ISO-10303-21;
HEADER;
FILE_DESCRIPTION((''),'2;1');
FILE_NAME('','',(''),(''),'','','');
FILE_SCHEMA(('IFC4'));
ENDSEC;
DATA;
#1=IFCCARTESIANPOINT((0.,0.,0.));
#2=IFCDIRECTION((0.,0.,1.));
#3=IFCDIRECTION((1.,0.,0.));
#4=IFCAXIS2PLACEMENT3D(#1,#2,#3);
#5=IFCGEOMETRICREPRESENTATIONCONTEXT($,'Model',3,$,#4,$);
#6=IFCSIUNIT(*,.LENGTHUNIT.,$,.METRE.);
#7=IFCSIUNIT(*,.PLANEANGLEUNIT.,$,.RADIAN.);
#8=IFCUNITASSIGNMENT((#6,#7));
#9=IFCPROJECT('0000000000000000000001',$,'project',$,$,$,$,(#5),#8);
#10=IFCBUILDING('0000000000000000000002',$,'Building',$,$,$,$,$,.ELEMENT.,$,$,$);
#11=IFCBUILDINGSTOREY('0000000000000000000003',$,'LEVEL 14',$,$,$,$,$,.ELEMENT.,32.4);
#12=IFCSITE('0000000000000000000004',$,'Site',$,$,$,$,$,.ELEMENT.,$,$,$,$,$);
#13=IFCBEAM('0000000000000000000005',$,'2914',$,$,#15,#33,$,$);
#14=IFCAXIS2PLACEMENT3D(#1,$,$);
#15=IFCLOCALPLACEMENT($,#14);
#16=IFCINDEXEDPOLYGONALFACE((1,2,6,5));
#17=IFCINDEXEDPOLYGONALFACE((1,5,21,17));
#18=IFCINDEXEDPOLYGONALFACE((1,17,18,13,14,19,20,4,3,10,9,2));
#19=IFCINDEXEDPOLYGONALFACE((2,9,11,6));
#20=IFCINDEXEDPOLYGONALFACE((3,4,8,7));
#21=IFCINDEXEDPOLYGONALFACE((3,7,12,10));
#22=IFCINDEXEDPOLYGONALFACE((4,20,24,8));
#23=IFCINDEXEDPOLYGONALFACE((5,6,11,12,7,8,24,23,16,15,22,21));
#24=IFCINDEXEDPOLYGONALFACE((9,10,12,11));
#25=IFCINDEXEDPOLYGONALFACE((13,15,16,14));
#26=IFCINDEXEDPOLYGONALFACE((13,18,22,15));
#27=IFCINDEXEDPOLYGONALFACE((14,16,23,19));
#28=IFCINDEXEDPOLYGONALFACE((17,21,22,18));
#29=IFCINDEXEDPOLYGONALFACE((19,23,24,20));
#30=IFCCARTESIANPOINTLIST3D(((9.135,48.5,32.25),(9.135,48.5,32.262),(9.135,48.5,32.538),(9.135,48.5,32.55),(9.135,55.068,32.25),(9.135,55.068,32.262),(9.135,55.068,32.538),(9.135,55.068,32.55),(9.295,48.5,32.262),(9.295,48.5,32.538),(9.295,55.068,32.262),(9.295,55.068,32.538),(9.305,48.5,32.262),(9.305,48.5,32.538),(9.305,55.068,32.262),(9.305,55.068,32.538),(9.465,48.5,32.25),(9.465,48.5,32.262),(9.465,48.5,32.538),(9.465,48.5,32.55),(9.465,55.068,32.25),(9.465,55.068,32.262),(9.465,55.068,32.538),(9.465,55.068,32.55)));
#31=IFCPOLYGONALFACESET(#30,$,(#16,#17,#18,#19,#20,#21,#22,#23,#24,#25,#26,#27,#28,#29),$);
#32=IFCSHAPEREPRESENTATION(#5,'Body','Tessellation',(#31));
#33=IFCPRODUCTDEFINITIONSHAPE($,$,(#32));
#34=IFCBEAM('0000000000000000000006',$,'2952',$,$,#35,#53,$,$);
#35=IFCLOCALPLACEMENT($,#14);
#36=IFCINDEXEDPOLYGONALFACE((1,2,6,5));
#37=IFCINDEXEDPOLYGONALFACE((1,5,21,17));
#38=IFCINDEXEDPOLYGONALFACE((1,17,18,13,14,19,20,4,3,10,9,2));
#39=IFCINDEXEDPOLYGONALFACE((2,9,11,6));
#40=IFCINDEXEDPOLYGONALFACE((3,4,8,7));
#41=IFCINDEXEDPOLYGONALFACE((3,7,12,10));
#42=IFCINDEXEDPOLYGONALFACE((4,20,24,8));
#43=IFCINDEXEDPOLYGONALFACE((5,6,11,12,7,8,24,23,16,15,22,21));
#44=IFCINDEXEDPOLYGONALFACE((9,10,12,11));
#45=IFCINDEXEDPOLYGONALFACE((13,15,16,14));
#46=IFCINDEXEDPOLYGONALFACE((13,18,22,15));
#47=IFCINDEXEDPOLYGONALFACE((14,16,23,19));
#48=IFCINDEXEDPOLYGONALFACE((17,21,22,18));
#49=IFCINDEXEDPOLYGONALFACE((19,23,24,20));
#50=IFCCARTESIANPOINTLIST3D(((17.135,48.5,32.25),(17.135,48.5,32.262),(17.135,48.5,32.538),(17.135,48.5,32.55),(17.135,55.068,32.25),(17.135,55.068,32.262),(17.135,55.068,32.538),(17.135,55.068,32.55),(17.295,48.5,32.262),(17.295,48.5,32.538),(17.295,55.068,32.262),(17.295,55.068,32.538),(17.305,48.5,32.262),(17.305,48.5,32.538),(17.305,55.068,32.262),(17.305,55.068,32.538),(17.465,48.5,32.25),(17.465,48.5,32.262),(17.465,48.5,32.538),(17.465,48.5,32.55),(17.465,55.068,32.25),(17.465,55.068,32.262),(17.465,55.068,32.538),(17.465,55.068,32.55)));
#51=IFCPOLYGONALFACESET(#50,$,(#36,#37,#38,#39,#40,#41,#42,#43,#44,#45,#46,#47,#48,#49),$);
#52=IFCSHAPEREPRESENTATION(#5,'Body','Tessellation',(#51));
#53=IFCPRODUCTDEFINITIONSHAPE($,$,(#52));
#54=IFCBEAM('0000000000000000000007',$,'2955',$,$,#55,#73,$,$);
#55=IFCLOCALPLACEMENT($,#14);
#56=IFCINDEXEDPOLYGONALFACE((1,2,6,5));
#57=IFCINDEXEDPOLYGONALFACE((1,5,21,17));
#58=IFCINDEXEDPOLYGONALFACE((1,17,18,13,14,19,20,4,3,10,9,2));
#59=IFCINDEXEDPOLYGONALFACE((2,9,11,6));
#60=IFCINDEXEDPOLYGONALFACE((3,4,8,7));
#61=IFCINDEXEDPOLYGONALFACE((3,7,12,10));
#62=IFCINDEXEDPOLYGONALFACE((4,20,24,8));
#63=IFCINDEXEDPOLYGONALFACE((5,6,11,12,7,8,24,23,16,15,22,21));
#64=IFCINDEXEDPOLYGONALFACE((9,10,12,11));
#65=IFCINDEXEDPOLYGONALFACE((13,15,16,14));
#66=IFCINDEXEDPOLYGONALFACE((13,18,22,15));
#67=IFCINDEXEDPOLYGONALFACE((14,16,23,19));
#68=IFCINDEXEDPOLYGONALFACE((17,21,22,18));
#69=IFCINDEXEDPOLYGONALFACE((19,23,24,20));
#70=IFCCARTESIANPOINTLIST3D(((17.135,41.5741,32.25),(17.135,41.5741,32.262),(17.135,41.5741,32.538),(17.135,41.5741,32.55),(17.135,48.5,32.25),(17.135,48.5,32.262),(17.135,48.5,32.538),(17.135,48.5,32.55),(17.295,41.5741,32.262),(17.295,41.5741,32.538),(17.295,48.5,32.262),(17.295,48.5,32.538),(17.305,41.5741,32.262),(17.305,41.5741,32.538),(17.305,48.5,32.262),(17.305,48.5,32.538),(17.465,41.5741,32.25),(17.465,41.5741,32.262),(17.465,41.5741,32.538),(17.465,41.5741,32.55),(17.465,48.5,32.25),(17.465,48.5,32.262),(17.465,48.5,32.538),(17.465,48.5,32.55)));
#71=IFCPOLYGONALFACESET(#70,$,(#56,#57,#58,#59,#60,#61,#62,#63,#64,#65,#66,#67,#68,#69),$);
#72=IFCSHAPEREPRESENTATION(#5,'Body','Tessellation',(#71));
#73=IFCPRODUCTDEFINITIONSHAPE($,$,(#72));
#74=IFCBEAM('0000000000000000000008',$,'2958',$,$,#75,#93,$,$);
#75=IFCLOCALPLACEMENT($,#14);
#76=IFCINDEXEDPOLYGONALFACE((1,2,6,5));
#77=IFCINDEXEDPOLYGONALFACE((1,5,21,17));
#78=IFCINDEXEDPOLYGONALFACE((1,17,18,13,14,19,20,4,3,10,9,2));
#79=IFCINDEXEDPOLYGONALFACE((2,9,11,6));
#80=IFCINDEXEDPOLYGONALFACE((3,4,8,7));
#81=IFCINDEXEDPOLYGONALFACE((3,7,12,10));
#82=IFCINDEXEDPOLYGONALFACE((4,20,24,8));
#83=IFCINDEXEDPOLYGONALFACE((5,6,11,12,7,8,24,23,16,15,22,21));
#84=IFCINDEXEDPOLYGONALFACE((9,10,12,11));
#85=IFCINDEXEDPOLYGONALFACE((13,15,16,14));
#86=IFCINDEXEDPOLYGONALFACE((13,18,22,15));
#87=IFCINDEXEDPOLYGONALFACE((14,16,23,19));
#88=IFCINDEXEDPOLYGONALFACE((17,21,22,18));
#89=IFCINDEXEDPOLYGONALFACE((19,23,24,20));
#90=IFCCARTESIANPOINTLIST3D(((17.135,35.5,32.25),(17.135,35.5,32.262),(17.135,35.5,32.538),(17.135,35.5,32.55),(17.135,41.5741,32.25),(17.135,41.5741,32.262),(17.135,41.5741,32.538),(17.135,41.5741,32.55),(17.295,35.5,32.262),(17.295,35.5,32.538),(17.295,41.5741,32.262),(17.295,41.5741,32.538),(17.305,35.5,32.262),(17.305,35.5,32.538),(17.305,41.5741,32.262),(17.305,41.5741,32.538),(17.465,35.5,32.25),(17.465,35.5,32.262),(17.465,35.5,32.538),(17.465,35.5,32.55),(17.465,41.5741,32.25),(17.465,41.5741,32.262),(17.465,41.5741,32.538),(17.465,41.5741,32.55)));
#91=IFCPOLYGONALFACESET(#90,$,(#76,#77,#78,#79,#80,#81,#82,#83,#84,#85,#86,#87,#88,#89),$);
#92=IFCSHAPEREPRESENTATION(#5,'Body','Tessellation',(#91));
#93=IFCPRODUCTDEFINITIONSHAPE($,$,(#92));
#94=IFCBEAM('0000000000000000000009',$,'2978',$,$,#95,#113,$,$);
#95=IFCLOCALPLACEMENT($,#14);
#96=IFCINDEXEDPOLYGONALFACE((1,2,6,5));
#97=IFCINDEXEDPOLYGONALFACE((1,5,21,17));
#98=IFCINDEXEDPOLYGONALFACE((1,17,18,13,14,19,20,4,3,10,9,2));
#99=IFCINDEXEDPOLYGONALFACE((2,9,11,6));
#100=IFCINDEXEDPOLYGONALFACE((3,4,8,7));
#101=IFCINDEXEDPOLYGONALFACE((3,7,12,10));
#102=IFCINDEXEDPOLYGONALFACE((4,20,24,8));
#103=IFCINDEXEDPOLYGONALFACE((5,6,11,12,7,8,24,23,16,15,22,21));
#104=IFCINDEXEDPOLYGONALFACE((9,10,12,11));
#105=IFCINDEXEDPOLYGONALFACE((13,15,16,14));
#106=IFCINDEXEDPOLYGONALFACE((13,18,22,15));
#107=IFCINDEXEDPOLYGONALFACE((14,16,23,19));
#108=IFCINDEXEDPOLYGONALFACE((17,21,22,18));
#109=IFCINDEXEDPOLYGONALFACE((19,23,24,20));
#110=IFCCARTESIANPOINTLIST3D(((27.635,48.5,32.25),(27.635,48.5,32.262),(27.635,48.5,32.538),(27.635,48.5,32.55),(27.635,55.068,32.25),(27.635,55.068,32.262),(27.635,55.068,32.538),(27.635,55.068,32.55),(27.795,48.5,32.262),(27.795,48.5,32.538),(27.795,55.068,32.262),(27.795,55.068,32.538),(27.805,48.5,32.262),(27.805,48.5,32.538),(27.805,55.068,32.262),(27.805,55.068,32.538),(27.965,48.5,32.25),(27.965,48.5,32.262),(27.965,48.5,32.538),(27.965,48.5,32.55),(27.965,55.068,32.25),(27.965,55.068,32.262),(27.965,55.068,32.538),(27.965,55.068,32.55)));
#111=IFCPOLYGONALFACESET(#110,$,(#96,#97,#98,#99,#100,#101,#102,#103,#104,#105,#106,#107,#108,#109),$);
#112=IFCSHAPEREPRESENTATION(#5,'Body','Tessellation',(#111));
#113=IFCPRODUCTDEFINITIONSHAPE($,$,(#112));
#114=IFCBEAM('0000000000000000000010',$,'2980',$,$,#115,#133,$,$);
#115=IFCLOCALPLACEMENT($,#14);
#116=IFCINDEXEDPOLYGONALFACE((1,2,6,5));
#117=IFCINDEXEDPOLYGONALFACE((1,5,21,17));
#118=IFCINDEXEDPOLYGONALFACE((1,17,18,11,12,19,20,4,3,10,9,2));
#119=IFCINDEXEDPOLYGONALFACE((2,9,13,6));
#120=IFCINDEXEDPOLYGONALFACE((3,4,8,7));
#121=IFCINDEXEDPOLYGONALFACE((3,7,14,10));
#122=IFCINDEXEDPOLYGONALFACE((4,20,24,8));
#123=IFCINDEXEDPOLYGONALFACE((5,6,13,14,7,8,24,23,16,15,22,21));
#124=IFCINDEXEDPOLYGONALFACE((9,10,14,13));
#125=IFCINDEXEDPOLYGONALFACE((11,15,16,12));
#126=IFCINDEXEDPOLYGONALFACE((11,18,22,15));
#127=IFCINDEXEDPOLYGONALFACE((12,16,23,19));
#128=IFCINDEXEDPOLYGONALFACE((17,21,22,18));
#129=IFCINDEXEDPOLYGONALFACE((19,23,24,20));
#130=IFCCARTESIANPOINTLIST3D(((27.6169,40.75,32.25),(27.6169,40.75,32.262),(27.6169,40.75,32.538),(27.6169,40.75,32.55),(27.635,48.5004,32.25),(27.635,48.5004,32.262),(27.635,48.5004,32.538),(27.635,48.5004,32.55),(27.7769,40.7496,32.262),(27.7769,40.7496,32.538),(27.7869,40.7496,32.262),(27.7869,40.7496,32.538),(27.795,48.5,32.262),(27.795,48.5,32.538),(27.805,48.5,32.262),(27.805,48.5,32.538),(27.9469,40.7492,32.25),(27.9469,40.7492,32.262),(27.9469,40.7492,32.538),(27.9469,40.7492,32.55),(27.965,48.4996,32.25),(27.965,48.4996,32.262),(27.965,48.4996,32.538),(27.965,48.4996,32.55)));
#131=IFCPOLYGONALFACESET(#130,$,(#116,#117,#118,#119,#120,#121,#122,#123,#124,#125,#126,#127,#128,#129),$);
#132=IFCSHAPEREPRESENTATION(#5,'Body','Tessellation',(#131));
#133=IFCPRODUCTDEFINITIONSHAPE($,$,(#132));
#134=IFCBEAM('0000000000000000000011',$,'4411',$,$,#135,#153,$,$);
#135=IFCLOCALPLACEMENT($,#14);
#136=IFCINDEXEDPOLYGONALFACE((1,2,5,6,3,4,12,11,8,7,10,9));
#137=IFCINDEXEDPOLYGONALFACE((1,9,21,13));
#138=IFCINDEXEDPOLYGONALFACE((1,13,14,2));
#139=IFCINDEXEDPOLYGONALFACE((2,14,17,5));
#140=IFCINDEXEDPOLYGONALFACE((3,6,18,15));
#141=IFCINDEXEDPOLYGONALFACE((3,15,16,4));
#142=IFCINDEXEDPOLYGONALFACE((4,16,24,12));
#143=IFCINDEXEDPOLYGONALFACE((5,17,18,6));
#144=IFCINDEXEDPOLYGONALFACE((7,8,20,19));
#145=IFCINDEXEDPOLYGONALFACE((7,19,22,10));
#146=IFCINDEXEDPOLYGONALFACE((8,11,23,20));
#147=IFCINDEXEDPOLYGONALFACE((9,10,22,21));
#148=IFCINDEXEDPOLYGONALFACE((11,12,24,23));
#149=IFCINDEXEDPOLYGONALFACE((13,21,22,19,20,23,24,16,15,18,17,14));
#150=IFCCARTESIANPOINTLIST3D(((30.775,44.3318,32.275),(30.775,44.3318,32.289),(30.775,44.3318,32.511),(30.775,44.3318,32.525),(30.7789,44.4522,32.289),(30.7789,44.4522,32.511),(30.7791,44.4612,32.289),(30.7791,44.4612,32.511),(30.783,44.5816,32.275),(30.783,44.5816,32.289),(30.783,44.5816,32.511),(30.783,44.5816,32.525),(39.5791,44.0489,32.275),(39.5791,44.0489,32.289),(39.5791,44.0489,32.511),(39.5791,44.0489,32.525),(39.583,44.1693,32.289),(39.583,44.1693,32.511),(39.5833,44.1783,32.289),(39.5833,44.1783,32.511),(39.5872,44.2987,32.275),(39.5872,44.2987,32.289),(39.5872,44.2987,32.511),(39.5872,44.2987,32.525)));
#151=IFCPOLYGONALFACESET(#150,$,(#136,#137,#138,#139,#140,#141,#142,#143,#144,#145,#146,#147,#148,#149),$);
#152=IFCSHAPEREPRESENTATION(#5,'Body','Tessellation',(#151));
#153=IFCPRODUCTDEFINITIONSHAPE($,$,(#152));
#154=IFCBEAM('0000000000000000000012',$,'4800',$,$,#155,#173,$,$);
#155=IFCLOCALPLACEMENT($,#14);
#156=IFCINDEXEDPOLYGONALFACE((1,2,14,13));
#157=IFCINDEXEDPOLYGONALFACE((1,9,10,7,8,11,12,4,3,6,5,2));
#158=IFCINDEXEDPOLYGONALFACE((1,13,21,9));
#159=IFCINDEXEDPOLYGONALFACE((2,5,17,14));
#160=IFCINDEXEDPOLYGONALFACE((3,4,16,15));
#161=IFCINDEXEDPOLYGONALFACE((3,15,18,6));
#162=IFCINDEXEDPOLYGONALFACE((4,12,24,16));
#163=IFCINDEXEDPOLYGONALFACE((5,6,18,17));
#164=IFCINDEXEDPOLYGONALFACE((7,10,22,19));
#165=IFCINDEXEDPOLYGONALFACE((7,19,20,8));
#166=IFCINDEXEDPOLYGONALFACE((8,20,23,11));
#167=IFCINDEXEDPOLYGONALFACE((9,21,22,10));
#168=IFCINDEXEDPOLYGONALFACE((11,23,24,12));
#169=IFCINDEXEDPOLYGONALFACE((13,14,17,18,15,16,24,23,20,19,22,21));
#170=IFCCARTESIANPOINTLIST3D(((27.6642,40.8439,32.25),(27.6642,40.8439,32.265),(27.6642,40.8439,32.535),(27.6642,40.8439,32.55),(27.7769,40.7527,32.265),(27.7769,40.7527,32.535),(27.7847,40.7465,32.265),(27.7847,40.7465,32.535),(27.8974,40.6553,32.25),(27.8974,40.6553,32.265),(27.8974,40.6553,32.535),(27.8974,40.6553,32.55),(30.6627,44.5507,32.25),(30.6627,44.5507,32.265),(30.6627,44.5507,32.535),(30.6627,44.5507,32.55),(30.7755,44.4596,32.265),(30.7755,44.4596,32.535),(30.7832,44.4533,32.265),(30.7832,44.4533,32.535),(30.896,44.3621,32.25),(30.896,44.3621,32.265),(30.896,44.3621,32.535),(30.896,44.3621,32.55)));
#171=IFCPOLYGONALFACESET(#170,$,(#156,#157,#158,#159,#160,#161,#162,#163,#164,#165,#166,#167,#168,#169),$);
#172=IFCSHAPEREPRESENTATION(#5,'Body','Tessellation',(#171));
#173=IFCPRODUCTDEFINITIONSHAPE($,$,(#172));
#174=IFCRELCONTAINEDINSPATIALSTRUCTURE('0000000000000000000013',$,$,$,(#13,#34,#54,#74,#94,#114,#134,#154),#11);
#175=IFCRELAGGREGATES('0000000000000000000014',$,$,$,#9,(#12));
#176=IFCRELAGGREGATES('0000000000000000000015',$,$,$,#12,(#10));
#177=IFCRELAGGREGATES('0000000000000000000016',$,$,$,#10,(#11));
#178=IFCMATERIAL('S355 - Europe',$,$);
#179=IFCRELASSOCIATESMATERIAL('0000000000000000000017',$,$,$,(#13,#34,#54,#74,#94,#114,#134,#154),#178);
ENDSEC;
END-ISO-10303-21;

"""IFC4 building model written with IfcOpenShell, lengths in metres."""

from ifc_helpers import new_model, si_unit, frame, origin_with_axes, origin_2d_with_axis, place, context, project, spatial, i_section, extrude, material, material_profile, profile_set, profile_usage, element, save


model = new_model("IFC4")

# Units and contexts
model_context = context("Model", 3, world=origin_with_axes())
ifc_project = project(units=[si_unit("LENGTHUNIT", "METRE"), si_unit("PLANEANGLEUNIT", "RADIAN")], contexts=[model_context])

# Site, building, storey
site = spatial("IfcSite", under=ifc_project, Name="Site", CompositionType="ELEMENT")
building = spatial("IfcBuilding", under=site, Name="Building", CompositionType="ELEMENT")
storey = spatial("IfcBuildingStorey", under=building, Name="LEVEL 14", CompositionType="ELEMENT", Elevation=32.4)

# Shared definitions
ifc_material = material(Name="S355 - Europe")

# Beams
ifc_material_profile_1 = material_profile(ifc_material, i_section(OverallWidth=0.33, OverallDepth=0.3, WebThickness=0.01, FlangeThickness=0.012, at=origin_2d_with_axis()))
ifc_profile_set_1 = profile_set([ifc_material_profile_1])
ifc_profile_usage_1 = profile_usage(ifc_profile_set_1, cardinal=10)
beam_1_placement = place(None, frame((9.3, 55.068, 32.4), z_axis=(0.0, -1.0, 0.0), x_axis=(1.0, 0.0, 0.0)))
element("IfcBeam", 1, at=beam_1_placement, inside=storey, material=ifc_profile_usage_1, Name="2914", context=model_context, shape_type="SweptSolid", body=[
    extrude(i_section(OverallWidth=0.33, OverallDepth=0.3, WebThickness=0.01, FlangeThickness=0.012, at=origin_2d_with_axis()), origin_with_axes(), (0.0, 0.0, 1.0), 6.568),
])
ifc_material_profile_2 = material_profile(ifc_material, i_section(OverallWidth=0.33, OverallDepth=0.3, WebThickness=0.01, FlangeThickness=0.012, at=origin_2d_with_axis()))
ifc_profile_set_2 = profile_set([ifc_material_profile_2])
ifc_profile_usage_2 = profile_usage(ifc_profile_set_2, cardinal=10)
beam_2_placement = place(None, frame((17.3, 55.068, 32.4), z_axis=(0.0, -1.0, 0.0), x_axis=(1.0, 0.0, 0.0)))
element("IfcBeam", 2, at=beam_2_placement, inside=storey, material=ifc_profile_usage_2, Name="2952", context=model_context, shape_type="SweptSolid", body=[
    extrude(i_section(OverallWidth=0.33, OverallDepth=0.3, WebThickness=0.01, FlangeThickness=0.012, at=origin_2d_with_axis()), origin_with_axes(), (0.0, 0.0, 1.0), 6.568),
])
ifc_material_profile_3 = material_profile(ifc_material, i_section(OverallWidth=0.33, OverallDepth=0.3, WebThickness=0.01, FlangeThickness=0.012, at=origin_2d_with_axis()))
ifc_profile_set_3 = profile_set([ifc_material_profile_3])
ifc_profile_usage_3 = profile_usage(ifc_profile_set_3, cardinal=10)
beam_3_placement = place(None, frame((17.3, 48.5, 32.4), z_axis=(0.0, -1.0, 0.0), x_axis=(1.0, 0.0, 0.0)))
element("IfcBeam", 3, at=beam_3_placement, inside=storey, material=ifc_profile_usage_3, Name="2955", context=model_context, shape_type="SweptSolid", body=[
    extrude(i_section(OverallWidth=0.33, OverallDepth=0.3, WebThickness=0.01, FlangeThickness=0.012, at=origin_2d_with_axis()), origin_with_axes(), (0.0, 0.0, 1.0), 6.9259),
])
ifc_material_profile_4 = material_profile(ifc_material, i_section(OverallWidth=0.33, OverallDepth=0.3, WebThickness=0.01, FlangeThickness=0.012, at=origin_2d_with_axis()))
ifc_profile_set_4 = profile_set([ifc_material_profile_4])
ifc_profile_usage_4 = profile_usage(ifc_profile_set_4, cardinal=10)
beam_4_placement = place(None, frame((17.3, 41.5741, 32.4), z_axis=(0.0, -1.0, 0.0), x_axis=(1.0, 0.0, 0.0)))
element("IfcBeam", 4, at=beam_4_placement, inside=storey, material=ifc_profile_usage_4, Name="2958", context=model_context, shape_type="SweptSolid", body=[
    extrude(i_section(OverallWidth=0.33, OverallDepth=0.3, WebThickness=0.01, FlangeThickness=0.012, at=origin_2d_with_axis()), origin_with_axes(), (0.0, 0.0, 1.0), 6.0741),
])
ifc_material_profile_5 = material_profile(ifc_material, i_section(OverallWidth=0.33, OverallDepth=0.3, WebThickness=0.01, FlangeThickness=0.012, at=origin_2d_with_axis()))
ifc_profile_set_5 = profile_set([ifc_material_profile_5])
ifc_profile_usage_5 = profile_usage(ifc_profile_set_5, cardinal=10)
beam_5_placement = place(None, frame((27.8, 55.068, 32.4), z_axis=(0.0, -1.0, 0.0), x_axis=(1.0, 0.0, 0.0)))
element("IfcBeam", 5, at=beam_5_placement, inside=storey, material=ifc_profile_usage_5, Name="2978", context=model_context, shape_type="SweptSolid", body=[
    extrude(i_section(OverallWidth=0.33, OverallDepth=0.3, WebThickness=0.01, FlangeThickness=0.012, at=origin_2d_with_axis()), origin_with_axes(), (0.0, 0.0, 1.0), 6.568),
])
ifc_material_profile_6 = material_profile(ifc_material, i_section(OverallWidth=0.33, OverallDepth=0.3, WebThickness=0.01, FlangeThickness=0.012, at=origin_2d_with_axis()))
ifc_profile_set_6 = profile_set([ifc_material_profile_6])
ifc_profile_usage_6 = profile_usage(ifc_profile_set_6, cardinal=10)
beam_6_placement = place(None, frame((27.8, 48.5, 32.4), z_axis=(-0.002337, -0.999997, 0.0), x_axis=(0.999997, -0.002337, 0.0)))
element("IfcBeam", 6, at=beam_6_placement, inside=storey, material=ifc_profile_usage_6, Name="2980", context=model_context, shape_type="SweptSolid", body=[
    extrude(i_section(OverallWidth=0.33, OverallDepth=0.3, WebThickness=0.01, FlangeThickness=0.012, at=origin_2d_with_axis()), origin_with_axes(), (0.0, 0.0, 1.0), 7.7504),
])
ifc_material_profile_7 = material_profile(ifc_material, i_section(OverallWidth=0.25, OverallDepth=0.25, WebThickness=0.009, FlangeThickness=0.014, at=origin_2d_with_axis()))
ifc_profile_set_7 = profile_set([ifc_material_profile_7])
ifc_profile_usage_7 = profile_usage(ifc_profile_set_7, cardinal=10)
beam_7_placement = place(None, frame((30.779, 44.4567, 32.4), z_axis=(0.999484, -0.032117, 0.0), x_axis=(0.032117, 0.999484, 0.0)))
element("IfcBeam", 7, at=beam_7_placement, inside=storey, material=ifc_profile_usage_7, Name="4411", context=model_context, shape_type="SweptSolid", body=[
    extrude(i_section(OverallWidth=0.25, OverallDepth=0.25, WebThickness=0.009, FlangeThickness=0.014, at=origin_2d_with_axis()), origin_with_axes(), (0.0, 0.0, 1.0), 8.8087),
])
ifc_material_profile_8 = material_profile(ifc_material, i_section(OverallWidth=0.3, OverallDepth=0.3, WebThickness=0.01, FlangeThickness=0.015, at=origin_2d_with_axis()))
ifc_profile_set_8 = profile_set([ifc_material_profile_8])
ifc_profile_usage_8 = profile_usage(ifc_profile_set_8, cardinal=10)
beam_8_placement = place(None, frame((27.7808, 40.7496, 32.4), z_axis=(0.62892, 0.77747, 0.0), x_axis=(-0.777826, 0.62848, 0.0)))
element("IfcBeam", 8, at=beam_8_placement, inside=storey, material=ifc_profile_usage_8, Name="4800", context=model_context, shape_type="SweptSolid", body=[
    extrude(i_section(OverallWidth=0.3, OverallDepth=0.3, WebThickness=0.01, FlangeThickness=0.015, at=origin_2d_with_axis()), origin_with_axes(), (0.0, 0.0, 1.0), 4.7678),
])

save(model, "model.ifc")
